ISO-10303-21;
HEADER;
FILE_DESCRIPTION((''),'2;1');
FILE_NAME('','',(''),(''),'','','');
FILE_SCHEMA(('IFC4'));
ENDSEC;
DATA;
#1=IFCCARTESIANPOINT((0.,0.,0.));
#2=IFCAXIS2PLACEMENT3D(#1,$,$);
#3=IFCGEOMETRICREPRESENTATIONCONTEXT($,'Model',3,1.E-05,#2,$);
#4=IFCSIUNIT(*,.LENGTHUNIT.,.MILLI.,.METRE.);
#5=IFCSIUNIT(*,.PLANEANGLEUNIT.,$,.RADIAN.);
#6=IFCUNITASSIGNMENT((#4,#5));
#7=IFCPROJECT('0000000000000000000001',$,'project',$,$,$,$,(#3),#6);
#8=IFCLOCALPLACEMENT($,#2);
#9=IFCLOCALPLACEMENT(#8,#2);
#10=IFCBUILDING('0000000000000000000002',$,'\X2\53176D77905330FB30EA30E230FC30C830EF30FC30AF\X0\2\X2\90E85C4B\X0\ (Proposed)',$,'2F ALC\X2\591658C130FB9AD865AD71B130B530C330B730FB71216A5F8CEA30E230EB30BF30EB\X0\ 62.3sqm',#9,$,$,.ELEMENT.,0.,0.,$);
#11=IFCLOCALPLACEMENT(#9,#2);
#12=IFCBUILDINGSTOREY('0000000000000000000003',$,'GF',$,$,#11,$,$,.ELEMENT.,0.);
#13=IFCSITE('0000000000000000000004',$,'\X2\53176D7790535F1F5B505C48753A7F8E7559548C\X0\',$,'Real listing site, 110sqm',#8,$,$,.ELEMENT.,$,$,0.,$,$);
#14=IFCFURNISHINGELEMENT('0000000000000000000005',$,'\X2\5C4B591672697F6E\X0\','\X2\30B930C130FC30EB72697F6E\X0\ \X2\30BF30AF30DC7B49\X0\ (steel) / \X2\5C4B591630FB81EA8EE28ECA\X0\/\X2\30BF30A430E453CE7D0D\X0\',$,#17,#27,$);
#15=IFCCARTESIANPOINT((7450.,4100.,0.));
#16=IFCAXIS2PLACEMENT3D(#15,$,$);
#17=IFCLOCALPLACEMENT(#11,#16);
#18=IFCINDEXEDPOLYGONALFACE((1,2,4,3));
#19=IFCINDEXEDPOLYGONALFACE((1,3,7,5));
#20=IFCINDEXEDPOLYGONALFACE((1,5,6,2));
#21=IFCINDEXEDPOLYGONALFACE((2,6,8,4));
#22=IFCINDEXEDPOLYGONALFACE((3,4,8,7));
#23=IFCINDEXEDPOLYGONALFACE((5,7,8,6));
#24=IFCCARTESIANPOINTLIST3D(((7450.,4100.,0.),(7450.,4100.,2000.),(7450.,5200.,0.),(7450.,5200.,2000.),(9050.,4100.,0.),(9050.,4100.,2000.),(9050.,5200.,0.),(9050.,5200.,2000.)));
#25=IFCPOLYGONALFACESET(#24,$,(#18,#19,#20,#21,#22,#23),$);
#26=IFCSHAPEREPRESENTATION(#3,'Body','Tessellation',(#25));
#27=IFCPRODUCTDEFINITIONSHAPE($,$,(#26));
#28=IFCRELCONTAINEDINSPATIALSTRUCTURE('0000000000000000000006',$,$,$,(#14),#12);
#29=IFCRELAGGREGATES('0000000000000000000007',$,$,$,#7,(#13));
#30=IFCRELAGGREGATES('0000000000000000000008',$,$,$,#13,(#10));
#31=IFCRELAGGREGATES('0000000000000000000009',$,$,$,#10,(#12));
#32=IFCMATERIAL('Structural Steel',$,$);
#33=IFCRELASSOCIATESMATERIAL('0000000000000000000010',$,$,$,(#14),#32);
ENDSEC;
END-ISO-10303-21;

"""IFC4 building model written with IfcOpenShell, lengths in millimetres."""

from ifc_helpers import new_model, si_unit, frame, frame_2d, origin, place, context, project, spatial, rectangle, extrude, material, element, save


model = new_model("IFC4")

# Units and contexts
model_context = context("Model", 3, precision=1e-05, world=origin())
ifc_project = project(units=[si_unit("LENGTHUNIT", "METRE", prefix="MILLI"), si_unit("PLANEANGLEUNIT", "RADIAN")], contexts=[model_context])

# Site, building, storey
site_placement = place(None, origin())
site = spatial("IfcSite", under=ifc_project, at=site_placement, Name="北海道弟子屈町美留和", ObjectType="Real listing site, 110sqm", CompositionType="ELEMENT", RefElevation=0.0)
building_placement = place(site_placement, origin())
building = spatial("IfcBuilding", under=site, at=building_placement, Name="北海道・リモートワーク2部屋 (Proposed)", ObjectType="2F ALC外壁・高断熱サッシ・無機質モルタル 62.3sqm", CompositionType="ELEMENT", ElevationOfRefHeight=0.0, ElevationOfTerrain=0.0)
storey_placement = place(building_placement, origin())
storey = spatial("IfcBuildingStorey", under=building, at=storey_placement, Name="GF", CompositionType="ELEMENT", Elevation=0.0)

# Shared definitions
ifc_material_1 = material(Name="Structural Steel")

# Furnishing element
furnishing_1_placement = place(storey_placement, frame((7450.0, 4100.0, 0.0)))
element("IfcFurnishingElement", 1, at=furnishing_1_placement, inside=storey, material=ifc_material_1, Name="屋外物置", Description="スチール物置 タクボ等 (steel) / 屋外・自転車/タイヤ収納", context=model_context, shape_type="SweptSolid", body=[
    extrude(rectangle(XDim=1600.0, YDim=1100.0, at=frame_2d((800.0, 550.0))), frame((7450.0, 4100.0, 0.0)), (0.0, 0.0, 1.0), 2000.0),
])

save(model, "model.ifc")
